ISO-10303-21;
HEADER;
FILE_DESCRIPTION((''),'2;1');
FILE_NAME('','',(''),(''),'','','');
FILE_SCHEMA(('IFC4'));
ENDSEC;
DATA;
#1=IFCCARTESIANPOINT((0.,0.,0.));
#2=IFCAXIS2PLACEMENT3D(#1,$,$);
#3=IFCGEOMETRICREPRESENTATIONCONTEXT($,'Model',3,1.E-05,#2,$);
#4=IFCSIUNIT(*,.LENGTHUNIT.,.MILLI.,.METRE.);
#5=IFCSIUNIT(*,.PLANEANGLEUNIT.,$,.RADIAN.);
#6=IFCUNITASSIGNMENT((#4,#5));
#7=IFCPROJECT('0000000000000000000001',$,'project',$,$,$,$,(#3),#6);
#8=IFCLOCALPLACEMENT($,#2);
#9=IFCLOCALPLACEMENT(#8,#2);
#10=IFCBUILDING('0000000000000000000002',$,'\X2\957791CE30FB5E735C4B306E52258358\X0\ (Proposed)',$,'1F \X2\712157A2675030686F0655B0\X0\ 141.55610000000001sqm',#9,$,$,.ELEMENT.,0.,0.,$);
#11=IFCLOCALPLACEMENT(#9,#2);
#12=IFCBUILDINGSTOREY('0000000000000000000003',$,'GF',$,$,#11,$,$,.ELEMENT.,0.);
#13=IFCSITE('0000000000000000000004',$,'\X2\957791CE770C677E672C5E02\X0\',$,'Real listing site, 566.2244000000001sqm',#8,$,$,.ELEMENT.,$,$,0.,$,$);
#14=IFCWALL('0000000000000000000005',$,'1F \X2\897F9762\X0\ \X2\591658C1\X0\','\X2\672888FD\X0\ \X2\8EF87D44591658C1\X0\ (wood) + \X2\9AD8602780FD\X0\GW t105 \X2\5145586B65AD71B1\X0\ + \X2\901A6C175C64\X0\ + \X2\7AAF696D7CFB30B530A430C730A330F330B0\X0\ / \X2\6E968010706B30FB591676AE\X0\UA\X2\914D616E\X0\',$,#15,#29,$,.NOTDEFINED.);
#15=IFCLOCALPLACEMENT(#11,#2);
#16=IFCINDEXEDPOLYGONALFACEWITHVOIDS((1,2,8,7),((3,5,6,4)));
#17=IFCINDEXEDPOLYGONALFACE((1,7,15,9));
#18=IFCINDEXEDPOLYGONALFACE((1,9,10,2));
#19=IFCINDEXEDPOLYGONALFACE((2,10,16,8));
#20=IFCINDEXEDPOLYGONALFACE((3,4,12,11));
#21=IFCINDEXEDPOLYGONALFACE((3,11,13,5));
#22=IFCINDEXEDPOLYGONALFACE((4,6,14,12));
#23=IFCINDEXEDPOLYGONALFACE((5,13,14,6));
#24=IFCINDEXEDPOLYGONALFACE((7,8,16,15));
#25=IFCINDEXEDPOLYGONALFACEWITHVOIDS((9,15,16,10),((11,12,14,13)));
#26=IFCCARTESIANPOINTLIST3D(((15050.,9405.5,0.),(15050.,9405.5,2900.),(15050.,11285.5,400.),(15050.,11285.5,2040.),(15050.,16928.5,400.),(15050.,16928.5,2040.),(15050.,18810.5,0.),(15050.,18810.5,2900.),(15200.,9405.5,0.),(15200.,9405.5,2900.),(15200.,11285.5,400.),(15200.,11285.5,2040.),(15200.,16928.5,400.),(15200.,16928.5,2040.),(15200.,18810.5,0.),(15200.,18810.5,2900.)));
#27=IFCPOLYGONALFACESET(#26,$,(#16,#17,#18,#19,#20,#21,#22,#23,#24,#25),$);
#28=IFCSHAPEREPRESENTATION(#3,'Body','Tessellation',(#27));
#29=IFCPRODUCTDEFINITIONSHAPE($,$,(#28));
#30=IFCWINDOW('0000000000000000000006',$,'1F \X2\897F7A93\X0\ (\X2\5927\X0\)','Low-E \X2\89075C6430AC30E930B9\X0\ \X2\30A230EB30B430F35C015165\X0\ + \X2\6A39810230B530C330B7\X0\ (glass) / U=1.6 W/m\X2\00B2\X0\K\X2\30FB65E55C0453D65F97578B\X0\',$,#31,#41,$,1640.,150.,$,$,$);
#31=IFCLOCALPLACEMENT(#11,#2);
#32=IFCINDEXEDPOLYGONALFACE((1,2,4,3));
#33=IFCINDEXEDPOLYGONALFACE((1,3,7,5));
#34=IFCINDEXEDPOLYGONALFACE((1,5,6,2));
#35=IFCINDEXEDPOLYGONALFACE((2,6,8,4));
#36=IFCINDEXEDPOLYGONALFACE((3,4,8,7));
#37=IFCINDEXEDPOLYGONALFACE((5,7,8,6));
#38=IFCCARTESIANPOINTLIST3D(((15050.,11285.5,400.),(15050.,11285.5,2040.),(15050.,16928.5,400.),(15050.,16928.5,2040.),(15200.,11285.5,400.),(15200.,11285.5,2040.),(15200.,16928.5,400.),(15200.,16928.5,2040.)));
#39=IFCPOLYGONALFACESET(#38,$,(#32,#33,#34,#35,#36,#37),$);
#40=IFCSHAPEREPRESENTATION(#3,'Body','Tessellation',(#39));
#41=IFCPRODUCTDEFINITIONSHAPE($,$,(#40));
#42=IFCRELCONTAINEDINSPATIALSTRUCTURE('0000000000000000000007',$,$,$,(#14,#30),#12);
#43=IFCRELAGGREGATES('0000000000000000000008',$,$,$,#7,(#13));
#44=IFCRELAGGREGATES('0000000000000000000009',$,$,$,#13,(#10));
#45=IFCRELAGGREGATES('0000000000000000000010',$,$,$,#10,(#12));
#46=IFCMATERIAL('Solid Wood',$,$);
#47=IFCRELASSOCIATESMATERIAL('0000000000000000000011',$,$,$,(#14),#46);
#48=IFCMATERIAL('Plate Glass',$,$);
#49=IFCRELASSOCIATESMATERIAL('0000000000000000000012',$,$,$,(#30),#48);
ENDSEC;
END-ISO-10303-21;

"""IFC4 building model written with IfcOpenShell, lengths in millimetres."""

from ifc_helpers import new_model, si_unit, frame, frame_2d, origin, place, context, project, spatial, rectangle, extrude, material, element, fill, save


model = new_model("IFC4")

# Units and contexts
model_context = context("Model", 3, precision=1e-05, world=origin())
ifc_project = project(units=[si_unit("LENGTHUNIT", "METRE", prefix="MILLI"), si_unit("PLANEANGLEUNIT", "RADIAN")], contexts=[model_context])

# Site, building, storey
site_placement = place(None, origin())
site = spatial("IfcSite", under=ifc_project, at=site_placement, Name="長野県松本市", ObjectType="Real listing site, 566.2244000000001sqm", CompositionType="ELEMENT", RefElevation=0.0)
building_placement = place(site_placement, origin())
building = spatial("IfcBuilding", under=site, at=building_placement, Name="長野・平屋の別荘 (Proposed)", ObjectType="1F 無垢材と漆喰 141.55610000000001sqm", CompositionType="ELEMENT", ElevationOfRefHeight=0.0, ElevationOfTerrain=0.0)
storey_placement = place(building_placement, origin())
storey = spatial("IfcBuildingStorey", under=building, at=storey_placement, Name="GF", CompositionType="ELEMENT", Elevation=0.0)

# Shared definitions
ifc_material_1 = material(Name="Solid Wood")

# Shared definitions
ifc_material_2 = material(Name="Plate Glass")

# Wall, opening, window
wall_1_placement = place(storey_placement, frame((7525.0, 4703.0, 0.0)))
wall_1 = element("IfcWall", 1, at=wall_1_placement, inside=storey, material=ifc_material_1, Name="1F 西面 外壁", Description="木製 軸組外壁 (wood) + 高性能GW t105 充填断熱 + 通気層 + 窯業系サイディング / 準耐火・外皮UA配慮", PredefinedType="NOTDEFINED", context=model_context, shape_type="SweptSolid", body=[
    extrude(rectangle(XDim=150.0, YDim=9405.0, at=frame_2d((75.0, 4702.0))), frame((7525.0, 4703.0, 0.0)), (0.0, 0.0, 1.0), 2900.0),
])
opening_1_placement = place(storey_placement, frame((7525.0, 5643.0, 200.0)))
opening_1 = element("IfcOpeningElement", 2, at=opening_1_placement, cuts=wall_1, PredefinedType="NOTDEFINED", context=model_context, shape_type="SweptSolid", body=[
    extrude(rectangle(XDim=150.0, YDim=5643.0, at=frame_2d((75.0, 2821.0))), frame((7525.0, 5643.0, 200.0)), (0.0, 0.0, 1.0), 1640.0),
])
window_1_placement = place(storey_placement, frame((7525.0, 5643.0, 200.0)))
window_1 = element("IfcWindow", 3, at=window_1_placement, inside=storey, material=ifc_material_2, Name="1F 西窓 (大)", Description="Low-E 複層ガラス アルゴン封入 + 樹脂サッシ (glass) / U=1.6 W/m²K・日射取得型", OverallHeight=1640.0, OverallWidth=150.0, context=model_context, shape_type="SweptSolid", body=[
    extrude(rectangle(XDim=150.0, YDim=5643.0, at=frame_2d((75.0, 2821.0))), frame((7525.0, 5643.0, 200.0)), (0.0, 0.0, 1.0), 1640.0),
])
fill(opening_1, window_1)

save(model, "model.ifc")
